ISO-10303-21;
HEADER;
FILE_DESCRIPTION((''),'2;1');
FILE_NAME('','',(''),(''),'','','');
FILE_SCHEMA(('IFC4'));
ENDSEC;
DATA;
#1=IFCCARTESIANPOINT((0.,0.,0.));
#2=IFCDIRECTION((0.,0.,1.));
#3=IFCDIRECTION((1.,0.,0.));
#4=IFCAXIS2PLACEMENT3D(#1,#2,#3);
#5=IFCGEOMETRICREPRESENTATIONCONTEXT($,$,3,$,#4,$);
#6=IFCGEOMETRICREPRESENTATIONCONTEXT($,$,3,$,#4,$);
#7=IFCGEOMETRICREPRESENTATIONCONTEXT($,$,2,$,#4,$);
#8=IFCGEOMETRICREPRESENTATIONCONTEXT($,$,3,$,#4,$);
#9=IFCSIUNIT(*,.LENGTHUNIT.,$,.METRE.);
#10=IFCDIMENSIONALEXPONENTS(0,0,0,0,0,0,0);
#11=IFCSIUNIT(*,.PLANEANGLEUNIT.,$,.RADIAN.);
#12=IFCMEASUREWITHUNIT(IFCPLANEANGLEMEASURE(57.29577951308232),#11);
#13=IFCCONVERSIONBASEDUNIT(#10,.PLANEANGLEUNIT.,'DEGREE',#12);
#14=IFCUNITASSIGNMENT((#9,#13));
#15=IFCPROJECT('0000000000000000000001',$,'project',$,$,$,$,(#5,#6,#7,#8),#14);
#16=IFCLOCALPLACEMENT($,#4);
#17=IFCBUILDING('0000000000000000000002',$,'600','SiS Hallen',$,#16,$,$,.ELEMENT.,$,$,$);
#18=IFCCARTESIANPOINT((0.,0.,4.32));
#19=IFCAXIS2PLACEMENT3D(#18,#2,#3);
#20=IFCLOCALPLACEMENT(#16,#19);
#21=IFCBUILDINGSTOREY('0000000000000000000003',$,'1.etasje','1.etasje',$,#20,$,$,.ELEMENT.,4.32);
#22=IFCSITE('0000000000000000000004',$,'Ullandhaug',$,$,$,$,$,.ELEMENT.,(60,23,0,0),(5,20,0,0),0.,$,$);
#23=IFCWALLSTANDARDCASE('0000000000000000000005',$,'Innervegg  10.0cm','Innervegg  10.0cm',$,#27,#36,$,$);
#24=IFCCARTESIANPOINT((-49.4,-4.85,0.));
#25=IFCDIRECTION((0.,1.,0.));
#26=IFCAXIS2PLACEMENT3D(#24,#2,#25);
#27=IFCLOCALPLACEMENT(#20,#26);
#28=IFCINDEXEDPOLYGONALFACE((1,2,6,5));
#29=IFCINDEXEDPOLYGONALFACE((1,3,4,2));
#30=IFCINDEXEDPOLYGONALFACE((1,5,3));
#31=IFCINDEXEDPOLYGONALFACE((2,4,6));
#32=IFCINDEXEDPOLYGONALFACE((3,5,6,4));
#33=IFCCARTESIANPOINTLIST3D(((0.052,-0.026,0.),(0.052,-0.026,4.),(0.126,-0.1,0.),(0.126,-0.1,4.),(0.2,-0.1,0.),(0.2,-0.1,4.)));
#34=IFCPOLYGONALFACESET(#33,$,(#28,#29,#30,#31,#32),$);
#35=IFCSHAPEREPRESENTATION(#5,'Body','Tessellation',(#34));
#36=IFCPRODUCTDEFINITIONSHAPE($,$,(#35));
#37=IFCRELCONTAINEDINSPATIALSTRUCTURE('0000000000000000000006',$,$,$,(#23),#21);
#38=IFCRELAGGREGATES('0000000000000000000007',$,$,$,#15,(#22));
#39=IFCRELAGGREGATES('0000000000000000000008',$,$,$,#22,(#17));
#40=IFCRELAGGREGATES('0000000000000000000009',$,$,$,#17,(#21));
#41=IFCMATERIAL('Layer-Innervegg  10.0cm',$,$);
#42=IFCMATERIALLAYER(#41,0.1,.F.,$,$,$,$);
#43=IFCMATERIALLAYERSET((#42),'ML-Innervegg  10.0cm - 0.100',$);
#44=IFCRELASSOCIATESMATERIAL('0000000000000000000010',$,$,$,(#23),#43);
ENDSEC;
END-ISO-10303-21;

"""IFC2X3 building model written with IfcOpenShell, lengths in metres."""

from ifc_helpers import new_model, entity, si_unit, converted_unit, frame, origin_with_axes, place, context, project, spatial, polyline, outline, extrude, material, layer, layer_set, layer_usage, element, save


model = new_model("IFC2X3")

# Units and contexts
context_of_model_1 = context(None, 3, world=origin_with_axes())
context_of_model_2 = context(None, 3, world=origin_with_axes())
context_of_model_3 = context(None, 2, world=origin_with_axes())
context_of_model_4 = context(None, 3, world=origin_with_axes())
ifc_project = project(units=[si_unit("LENGTHUNIT", "METRE"), converted_unit("PLANEANGLEUNIT", "DEGREE", entity("IfcPlaneAngleMeasure", 57.29577951308232), si_unit("PLANEANGLEUNIT", "RADIAN"), dimensions=[0, 0, 0, 0, 0, 0, 0])], contexts=[context_of_model_1, context_of_model_2, context_of_model_3, context_of_model_4])

# Site, building, storey
site = spatial("IfcSite", under=ifc_project, Name="Ullandhaug", CompositionType="ELEMENT", RefLatitude=(60, 23, 0, 0), RefLongitude=(5, 20, 0, 0), RefElevation=0.0)
building_placement = place(None, origin_with_axes())
building = spatial("IfcBuilding", under=site, at=building_placement, Name="600", Description="SiS Hallen", CompositionType="ELEMENT")
storey_placement = place(building_placement, frame((0.0, 0.0, 4.32), z_axis=(0.0, 0.0, 1.0), x_axis=(1.0, 0.0, 0.0)))
storey = spatial("IfcBuildingStorey", under=building, at=storey_placement, Name="1.etasje", Description="1.etasje", CompositionType="ELEMENT", Elevation=4.32)

# Wall
ifc_material_1 = material(Name="Layer-Innervegg  10.0cm")
ifc_layer_1 = layer(ifc_material_1, 0.1, ventilated=False)
ifc_layer_set_1 = layer_set([ifc_layer_1], Name="ML-Innervegg  10.0cm - 0.100")
ifc_layer_usage_1 = layer_usage(ifc_layer_set_1, "AXIS2", "POSITIVE", 0.0)
wall_1_placement = place(storey_placement, frame((-49.4, -4.85, 0.0), z_axis=(0.0, 0.0, 1.0), x_axis=(0.0, 1.0, 0.0)))
element("IfcWallStandardCase", 1, at=wall_1_placement, inside=storey, material=ifc_layer_usage_1, Name="Innervegg  10.0cm", Description="Innervegg  10.0cm", context=context_of_model_1, shape_type="SweptSolid", body=[
    extrude(outline(polyline([(0.0, 0.0), (0.026, 0.0), (0.126, 0.1), (0.2, 0.1), (0.0, 0.0)])), frame((0.0, 0.0, 0.0), z_axis=(0.0, 0.0, -1.0), x_axis=(1.0, 0.0, 0.0)), (0.0, 0.0, -1.0), 4.0),
])

save(model, "model.ifc")
